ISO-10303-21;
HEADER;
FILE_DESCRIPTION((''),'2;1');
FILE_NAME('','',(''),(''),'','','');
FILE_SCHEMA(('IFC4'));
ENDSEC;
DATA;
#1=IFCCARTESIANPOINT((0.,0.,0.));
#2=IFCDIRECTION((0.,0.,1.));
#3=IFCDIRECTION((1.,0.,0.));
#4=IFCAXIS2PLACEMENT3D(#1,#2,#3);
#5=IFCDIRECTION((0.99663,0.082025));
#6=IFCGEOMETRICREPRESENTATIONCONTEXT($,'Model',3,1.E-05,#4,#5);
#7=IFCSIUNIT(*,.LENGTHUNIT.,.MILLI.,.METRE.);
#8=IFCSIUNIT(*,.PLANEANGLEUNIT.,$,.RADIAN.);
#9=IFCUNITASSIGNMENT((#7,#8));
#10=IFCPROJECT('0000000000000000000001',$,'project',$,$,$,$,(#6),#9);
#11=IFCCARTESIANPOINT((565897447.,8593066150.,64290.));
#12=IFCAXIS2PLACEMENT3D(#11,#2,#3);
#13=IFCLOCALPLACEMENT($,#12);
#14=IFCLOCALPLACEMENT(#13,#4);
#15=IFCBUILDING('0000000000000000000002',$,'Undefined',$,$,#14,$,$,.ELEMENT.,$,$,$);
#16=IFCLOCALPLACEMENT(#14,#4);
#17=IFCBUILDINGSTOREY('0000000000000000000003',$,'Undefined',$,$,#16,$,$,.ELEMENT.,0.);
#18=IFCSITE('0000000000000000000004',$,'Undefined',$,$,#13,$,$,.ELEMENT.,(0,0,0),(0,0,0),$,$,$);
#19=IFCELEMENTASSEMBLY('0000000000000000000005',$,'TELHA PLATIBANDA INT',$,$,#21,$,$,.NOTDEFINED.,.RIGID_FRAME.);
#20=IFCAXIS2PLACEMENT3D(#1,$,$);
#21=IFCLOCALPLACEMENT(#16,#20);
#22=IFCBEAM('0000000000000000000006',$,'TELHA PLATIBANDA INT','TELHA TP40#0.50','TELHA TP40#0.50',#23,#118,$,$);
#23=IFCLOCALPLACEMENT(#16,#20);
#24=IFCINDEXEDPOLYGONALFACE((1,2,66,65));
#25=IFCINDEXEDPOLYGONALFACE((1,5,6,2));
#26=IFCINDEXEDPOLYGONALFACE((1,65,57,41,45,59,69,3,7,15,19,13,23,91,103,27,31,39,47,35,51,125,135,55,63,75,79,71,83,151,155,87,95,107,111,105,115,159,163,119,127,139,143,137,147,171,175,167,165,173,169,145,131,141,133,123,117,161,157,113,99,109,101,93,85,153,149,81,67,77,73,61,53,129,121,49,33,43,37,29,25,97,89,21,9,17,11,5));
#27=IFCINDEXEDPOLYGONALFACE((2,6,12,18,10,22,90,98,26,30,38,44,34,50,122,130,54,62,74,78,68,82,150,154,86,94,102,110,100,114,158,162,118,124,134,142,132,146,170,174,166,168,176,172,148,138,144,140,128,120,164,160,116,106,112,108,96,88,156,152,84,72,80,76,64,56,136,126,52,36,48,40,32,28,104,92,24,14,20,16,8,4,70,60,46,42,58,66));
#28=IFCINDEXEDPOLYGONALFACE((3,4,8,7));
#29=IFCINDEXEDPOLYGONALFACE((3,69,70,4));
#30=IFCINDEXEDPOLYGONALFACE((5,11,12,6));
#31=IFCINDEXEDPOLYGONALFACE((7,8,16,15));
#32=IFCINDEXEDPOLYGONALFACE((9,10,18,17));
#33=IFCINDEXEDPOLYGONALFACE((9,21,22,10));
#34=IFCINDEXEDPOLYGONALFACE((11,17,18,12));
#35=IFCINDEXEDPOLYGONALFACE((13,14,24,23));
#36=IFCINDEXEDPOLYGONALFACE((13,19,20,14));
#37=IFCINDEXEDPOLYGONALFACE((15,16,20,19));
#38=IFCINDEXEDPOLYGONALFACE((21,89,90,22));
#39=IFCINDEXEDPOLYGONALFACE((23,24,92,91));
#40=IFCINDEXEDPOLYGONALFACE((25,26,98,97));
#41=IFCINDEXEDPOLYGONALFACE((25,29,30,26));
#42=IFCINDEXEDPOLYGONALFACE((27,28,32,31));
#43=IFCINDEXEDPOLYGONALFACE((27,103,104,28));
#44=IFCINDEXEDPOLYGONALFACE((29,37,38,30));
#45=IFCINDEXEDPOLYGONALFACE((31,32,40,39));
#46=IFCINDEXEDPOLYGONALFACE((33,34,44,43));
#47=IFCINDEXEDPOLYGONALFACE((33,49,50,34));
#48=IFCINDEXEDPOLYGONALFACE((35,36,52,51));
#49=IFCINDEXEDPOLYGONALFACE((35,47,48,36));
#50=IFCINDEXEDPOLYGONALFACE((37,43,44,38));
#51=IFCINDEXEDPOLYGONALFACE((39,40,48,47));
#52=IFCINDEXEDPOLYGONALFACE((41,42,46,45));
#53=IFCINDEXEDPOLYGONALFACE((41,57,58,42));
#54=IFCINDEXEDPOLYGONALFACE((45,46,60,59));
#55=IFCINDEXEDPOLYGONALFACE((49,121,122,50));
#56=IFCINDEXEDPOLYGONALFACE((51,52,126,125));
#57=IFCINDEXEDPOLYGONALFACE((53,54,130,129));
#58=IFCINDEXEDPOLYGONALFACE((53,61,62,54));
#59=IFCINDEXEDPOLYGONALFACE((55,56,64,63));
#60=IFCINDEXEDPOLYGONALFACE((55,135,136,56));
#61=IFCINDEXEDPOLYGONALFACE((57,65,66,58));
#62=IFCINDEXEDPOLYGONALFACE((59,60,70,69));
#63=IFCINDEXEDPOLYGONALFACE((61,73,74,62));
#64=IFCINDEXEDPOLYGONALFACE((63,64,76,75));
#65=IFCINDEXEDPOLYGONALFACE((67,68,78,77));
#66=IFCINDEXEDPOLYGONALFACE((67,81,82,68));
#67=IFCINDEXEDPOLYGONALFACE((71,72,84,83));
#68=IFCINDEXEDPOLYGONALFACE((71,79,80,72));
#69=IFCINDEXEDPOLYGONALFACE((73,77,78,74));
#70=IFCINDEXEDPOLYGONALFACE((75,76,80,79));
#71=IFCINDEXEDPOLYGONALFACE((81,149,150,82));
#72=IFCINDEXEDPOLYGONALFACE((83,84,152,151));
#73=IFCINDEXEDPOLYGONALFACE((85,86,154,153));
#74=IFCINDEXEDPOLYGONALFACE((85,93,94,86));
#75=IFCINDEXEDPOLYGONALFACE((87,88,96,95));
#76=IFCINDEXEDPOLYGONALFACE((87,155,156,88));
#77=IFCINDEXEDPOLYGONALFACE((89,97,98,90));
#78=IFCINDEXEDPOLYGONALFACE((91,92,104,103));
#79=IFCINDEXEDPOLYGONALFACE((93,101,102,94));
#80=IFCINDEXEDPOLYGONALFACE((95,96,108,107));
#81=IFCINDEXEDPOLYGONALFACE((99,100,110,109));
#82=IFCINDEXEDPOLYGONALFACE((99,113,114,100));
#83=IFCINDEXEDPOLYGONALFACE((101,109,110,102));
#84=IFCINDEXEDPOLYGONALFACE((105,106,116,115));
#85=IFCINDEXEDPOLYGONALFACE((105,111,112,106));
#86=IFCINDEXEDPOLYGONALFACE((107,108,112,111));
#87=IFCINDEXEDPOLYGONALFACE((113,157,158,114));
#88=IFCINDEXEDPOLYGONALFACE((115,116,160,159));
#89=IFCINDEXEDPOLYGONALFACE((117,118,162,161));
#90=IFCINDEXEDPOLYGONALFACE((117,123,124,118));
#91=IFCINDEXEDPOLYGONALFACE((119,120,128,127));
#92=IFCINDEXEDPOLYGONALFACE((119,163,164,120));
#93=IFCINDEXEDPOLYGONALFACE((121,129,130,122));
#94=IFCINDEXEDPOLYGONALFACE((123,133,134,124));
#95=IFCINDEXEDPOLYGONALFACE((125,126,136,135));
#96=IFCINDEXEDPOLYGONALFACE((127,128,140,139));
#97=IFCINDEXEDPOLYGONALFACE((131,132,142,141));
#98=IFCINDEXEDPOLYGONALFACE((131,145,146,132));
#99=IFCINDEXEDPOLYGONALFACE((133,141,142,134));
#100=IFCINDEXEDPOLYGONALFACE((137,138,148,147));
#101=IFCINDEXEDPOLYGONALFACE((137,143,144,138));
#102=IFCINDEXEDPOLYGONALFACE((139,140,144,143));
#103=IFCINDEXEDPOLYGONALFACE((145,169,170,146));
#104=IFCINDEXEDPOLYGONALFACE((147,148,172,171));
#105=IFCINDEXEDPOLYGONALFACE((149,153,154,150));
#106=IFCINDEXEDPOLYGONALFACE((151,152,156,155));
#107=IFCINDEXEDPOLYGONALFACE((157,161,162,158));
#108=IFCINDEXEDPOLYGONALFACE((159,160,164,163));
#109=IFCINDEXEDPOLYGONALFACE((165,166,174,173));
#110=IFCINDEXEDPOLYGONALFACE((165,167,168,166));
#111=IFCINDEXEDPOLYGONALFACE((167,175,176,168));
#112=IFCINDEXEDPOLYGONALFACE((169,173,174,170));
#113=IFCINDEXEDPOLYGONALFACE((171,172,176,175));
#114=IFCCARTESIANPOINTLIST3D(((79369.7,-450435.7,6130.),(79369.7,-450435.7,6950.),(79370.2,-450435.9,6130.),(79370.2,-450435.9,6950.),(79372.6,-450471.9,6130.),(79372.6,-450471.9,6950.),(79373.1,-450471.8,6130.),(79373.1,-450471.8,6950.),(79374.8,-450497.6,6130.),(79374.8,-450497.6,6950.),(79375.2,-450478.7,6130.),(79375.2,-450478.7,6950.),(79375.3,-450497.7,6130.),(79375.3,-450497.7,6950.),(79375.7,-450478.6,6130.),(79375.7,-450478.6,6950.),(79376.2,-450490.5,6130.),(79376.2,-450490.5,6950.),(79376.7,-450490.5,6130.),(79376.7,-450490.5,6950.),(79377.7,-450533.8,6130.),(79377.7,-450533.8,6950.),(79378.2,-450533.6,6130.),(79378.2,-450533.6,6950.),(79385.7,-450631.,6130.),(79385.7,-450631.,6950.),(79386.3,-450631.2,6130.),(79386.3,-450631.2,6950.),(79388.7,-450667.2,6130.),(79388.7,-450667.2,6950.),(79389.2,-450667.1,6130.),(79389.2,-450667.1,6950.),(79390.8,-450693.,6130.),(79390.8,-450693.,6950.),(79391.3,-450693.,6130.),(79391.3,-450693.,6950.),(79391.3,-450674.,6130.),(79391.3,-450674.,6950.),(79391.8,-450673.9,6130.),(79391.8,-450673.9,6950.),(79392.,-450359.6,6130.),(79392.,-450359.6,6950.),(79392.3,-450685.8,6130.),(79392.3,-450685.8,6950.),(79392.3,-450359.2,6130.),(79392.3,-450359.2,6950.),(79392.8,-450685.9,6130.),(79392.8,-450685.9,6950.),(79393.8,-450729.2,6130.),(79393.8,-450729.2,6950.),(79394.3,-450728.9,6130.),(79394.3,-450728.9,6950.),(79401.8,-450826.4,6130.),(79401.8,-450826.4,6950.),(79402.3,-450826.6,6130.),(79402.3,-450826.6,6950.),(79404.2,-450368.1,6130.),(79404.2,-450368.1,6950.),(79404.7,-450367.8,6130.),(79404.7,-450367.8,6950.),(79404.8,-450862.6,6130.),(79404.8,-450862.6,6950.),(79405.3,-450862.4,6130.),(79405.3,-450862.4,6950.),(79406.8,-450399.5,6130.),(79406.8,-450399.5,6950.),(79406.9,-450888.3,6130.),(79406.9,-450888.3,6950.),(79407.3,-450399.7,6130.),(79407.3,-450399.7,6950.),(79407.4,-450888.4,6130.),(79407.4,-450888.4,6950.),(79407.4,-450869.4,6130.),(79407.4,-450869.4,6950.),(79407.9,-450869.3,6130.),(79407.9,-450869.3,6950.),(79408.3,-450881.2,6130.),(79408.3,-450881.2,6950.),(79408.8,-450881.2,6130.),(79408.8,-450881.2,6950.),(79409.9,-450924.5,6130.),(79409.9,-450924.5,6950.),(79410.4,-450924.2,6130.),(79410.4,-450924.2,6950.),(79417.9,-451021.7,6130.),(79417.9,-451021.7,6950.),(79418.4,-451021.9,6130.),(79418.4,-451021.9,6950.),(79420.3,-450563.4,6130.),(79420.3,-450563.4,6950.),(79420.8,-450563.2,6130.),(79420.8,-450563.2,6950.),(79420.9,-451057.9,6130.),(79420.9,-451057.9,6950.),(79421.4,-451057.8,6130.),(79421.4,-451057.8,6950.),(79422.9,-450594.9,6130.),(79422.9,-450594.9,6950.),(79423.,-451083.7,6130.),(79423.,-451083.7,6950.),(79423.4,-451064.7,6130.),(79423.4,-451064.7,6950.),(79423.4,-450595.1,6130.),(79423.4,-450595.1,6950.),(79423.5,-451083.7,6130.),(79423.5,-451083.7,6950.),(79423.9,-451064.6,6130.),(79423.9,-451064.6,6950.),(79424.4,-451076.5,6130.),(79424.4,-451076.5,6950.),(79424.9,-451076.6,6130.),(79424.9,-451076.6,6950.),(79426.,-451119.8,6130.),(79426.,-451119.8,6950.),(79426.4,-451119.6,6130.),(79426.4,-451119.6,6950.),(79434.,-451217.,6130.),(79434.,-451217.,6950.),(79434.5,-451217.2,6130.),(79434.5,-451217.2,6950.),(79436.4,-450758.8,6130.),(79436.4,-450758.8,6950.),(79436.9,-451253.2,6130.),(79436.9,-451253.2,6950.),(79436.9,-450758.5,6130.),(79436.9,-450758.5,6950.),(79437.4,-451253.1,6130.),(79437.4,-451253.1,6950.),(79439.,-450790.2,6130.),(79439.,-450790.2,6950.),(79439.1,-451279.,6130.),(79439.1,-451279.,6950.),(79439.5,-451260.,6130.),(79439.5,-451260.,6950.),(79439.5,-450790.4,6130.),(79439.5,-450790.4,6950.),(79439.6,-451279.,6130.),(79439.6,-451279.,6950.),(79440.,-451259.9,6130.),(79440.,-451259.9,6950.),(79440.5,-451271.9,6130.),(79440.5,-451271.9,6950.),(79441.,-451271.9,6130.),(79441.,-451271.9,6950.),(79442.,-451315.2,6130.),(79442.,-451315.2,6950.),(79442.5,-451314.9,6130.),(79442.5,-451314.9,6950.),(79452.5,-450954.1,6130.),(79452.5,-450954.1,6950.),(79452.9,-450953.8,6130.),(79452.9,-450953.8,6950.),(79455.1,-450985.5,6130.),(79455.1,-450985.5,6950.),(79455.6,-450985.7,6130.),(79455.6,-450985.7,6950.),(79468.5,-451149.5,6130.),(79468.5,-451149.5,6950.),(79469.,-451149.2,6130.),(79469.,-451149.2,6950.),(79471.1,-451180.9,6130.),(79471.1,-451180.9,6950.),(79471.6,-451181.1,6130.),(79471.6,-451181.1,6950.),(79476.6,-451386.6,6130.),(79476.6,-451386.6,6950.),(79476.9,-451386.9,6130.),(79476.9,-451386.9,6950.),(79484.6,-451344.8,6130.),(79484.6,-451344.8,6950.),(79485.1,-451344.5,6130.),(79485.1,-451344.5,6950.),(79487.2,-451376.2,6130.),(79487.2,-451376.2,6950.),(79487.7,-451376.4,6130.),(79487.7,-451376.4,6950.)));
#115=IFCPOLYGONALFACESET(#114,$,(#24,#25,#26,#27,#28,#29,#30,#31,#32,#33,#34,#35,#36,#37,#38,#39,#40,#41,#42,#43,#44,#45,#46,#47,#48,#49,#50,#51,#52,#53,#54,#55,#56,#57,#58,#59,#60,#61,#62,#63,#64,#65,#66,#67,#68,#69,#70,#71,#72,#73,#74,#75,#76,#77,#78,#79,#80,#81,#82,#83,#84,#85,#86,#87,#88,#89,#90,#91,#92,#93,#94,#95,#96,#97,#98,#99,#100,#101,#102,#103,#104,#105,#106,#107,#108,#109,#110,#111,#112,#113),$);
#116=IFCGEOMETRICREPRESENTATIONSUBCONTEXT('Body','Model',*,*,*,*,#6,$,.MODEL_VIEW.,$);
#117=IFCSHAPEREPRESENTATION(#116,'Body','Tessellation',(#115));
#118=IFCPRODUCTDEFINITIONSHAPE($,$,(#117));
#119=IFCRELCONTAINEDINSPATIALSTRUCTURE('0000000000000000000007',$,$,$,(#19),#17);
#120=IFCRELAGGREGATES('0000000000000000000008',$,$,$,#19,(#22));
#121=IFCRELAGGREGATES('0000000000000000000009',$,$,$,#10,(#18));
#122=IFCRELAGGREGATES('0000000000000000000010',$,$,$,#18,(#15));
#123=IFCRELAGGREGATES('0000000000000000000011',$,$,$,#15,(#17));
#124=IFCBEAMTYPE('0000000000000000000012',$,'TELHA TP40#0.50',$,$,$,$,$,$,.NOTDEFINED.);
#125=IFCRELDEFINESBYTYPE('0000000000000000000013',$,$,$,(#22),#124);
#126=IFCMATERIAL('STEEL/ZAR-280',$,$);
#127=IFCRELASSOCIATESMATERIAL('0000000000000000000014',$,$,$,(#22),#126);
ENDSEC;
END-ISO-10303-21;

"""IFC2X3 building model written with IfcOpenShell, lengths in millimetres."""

from ifc_helpers import new_model, si_unit, direction, frame, origin_with_axes, place, context, subcontext, project, spatial, polyline, outline, extrude, material, type_object, element, aggregate, save


model = new_model("IFC2X3")

# Units and contexts
model_context = context("Model", 3, precision=1e-05, world=origin_with_axes(), true_north=direction((0.99663, 0.082025)))
body_context = subcontext(model_context, "Body", "Model", "MODEL_VIEW")
ifc_project = project(units=[si_unit("LENGTHUNIT", "METRE", prefix="MILLI"), si_unit("PLANEANGLEUNIT", "RADIAN")], contexts=[model_context])

# Site, building, storey
site_placement = place(None, frame((565897447.0, 8593066150.0, 64290.0), z_axis=(0.0, 0.0, 1.0), x_axis=(1.0, 0.0, 0.0)))
site = spatial("IfcSite", under=ifc_project, at=site_placement, Name="Undefined", CompositionType="ELEMENT", RefLatitude=(0, 0, 0), RefLongitude=(0, 0, 0))
building_placement = place(site_placement, origin_with_axes())
building = spatial("IfcBuilding", under=site, at=building_placement, Name="Undefined", CompositionType="ELEMENT")
storey_placement = place(building_placement, origin_with_axes())
storey = spatial("IfcBuildingStorey", under=building, at=storey_placement, Name="Undefined", CompositionType="ELEMENT", Elevation=0.0)

# Element assembly, beam
ifc_material_1 = material(Name="STEEL/ZAR-280")
assembly_1_placement = place(storey_placement, origin_with_axes())
assembly_1 = element("IfcElementAssembly", 1, at=assembly_1_placement, inside=storey, Name="TELHA PLATIBANDA INT", AssemblyPlace="NOTDEFINED", PredefinedType="RIGID_FRAME")
beam_type_1 = type_object("IfcBeamType", Name="TELHA TP40#0.50", PredefinedType="NOTDEFINED")
beam_1_placement = place(assembly_1_placement, frame((79426.1, -450874.0, 6950.0), z_axis=(0.99663, 0.082025, 0.0), x_axis=(0.0, 0.0, -1.0)))
beam_1 = element("IfcBeam", 2, at=beam_1_placement, type_object=beam_type_1, material=ifc_material_1, Name="TELHA PLATIBANDA INT", Description="TELHA TP40#0.50", ObjectType="TELHA TP40#0.50", context=body_context, shape_type="SweptSolid", body=[
    extrude(outline(polyline([(440.8, -19.8), (473.8, 20.2), (505.8, 20.2), (515.4, 8.6), (515.0, 8.3), (505.6, 19.8), (474.0, 19.8), (441.0, -20.2), (404.7, -20.2), (397.7, -18.2), (385.9, -18.2), (378.9, -20.2), (342.6, -20.2), (309.6, 19.8), (278.0, 19.8), (245.0, -20.2), (208.7, -20.2), (201.7, -18.2), (189.9, -18.2), (182.9, -20.2), (146.6, -20.2), (113.6, 19.8), (82.0, 19.8), (49.0, -20.2), (12.7, -20.2), (5.7, -18.2), (-6.1, -18.2), (-13.1, -20.2), (-49.4, -20.2), (-82.4, 19.8), (-114.0, 19.8), (-147.0, -20.2), (-183.3, -20.2), (-190.3, -18.2), (-202.1, -18.2), (-209.1, -20.2), (-245.4, -20.2), (-278.4, 19.8), (-310.0, 19.8), (-343.0, -20.2), (-379.3, -20.2), (-386.3, -18.2), (-398.1, -18.2), (-405.1, -20.2), (-441.4, -20.2), (-474.4, 19.8), (-506.0, 19.8), (-515.4, 8.3), (-515.8, 8.6), (-506.2, 20.2), (-474.2, 20.2), (-441.2, -19.8), (-405.2, -19.8), (-398.2, -17.8), (-386.2, -17.8), (-379.2, -19.8), (-343.2, -19.8), (-310.2, 20.2), (-278.2, 20.2), (-245.2, -19.8), (-209.2, -19.8), (-202.2, -17.8), (-190.2, -17.8), (-183.2, -19.8), (-147.2, -19.8), (-114.2, 20.2), (-82.2, 20.2), (-49.2, -19.8), (-13.2, -19.8), (-6.2, -17.8), (5.8, -17.8), (12.8, -19.8), (48.8, -19.8), (81.8, 20.2), (113.8, 20.2), (146.8, -19.8), (182.8, -19.8), (189.8, -17.8), (201.8, -17.8), (208.8, -19.8), (244.8, -19.8), (277.8, 20.2), (309.8, 20.2), (342.8, -19.8), (378.8, -19.8), (385.8, -17.8), (397.8, -17.8), (404.8, -19.8), (440.8, -19.8)])), frame((820.0, 0.0, 0.0), z_axis=(-1.0, 0.0, 0.0), x_axis=(0.0, -1.0, 0.0)), (0.0, 0.0, 1.0), 820.0),
])
aggregate(assembly_1, [beam_1])

save(model, "model.ifc")
